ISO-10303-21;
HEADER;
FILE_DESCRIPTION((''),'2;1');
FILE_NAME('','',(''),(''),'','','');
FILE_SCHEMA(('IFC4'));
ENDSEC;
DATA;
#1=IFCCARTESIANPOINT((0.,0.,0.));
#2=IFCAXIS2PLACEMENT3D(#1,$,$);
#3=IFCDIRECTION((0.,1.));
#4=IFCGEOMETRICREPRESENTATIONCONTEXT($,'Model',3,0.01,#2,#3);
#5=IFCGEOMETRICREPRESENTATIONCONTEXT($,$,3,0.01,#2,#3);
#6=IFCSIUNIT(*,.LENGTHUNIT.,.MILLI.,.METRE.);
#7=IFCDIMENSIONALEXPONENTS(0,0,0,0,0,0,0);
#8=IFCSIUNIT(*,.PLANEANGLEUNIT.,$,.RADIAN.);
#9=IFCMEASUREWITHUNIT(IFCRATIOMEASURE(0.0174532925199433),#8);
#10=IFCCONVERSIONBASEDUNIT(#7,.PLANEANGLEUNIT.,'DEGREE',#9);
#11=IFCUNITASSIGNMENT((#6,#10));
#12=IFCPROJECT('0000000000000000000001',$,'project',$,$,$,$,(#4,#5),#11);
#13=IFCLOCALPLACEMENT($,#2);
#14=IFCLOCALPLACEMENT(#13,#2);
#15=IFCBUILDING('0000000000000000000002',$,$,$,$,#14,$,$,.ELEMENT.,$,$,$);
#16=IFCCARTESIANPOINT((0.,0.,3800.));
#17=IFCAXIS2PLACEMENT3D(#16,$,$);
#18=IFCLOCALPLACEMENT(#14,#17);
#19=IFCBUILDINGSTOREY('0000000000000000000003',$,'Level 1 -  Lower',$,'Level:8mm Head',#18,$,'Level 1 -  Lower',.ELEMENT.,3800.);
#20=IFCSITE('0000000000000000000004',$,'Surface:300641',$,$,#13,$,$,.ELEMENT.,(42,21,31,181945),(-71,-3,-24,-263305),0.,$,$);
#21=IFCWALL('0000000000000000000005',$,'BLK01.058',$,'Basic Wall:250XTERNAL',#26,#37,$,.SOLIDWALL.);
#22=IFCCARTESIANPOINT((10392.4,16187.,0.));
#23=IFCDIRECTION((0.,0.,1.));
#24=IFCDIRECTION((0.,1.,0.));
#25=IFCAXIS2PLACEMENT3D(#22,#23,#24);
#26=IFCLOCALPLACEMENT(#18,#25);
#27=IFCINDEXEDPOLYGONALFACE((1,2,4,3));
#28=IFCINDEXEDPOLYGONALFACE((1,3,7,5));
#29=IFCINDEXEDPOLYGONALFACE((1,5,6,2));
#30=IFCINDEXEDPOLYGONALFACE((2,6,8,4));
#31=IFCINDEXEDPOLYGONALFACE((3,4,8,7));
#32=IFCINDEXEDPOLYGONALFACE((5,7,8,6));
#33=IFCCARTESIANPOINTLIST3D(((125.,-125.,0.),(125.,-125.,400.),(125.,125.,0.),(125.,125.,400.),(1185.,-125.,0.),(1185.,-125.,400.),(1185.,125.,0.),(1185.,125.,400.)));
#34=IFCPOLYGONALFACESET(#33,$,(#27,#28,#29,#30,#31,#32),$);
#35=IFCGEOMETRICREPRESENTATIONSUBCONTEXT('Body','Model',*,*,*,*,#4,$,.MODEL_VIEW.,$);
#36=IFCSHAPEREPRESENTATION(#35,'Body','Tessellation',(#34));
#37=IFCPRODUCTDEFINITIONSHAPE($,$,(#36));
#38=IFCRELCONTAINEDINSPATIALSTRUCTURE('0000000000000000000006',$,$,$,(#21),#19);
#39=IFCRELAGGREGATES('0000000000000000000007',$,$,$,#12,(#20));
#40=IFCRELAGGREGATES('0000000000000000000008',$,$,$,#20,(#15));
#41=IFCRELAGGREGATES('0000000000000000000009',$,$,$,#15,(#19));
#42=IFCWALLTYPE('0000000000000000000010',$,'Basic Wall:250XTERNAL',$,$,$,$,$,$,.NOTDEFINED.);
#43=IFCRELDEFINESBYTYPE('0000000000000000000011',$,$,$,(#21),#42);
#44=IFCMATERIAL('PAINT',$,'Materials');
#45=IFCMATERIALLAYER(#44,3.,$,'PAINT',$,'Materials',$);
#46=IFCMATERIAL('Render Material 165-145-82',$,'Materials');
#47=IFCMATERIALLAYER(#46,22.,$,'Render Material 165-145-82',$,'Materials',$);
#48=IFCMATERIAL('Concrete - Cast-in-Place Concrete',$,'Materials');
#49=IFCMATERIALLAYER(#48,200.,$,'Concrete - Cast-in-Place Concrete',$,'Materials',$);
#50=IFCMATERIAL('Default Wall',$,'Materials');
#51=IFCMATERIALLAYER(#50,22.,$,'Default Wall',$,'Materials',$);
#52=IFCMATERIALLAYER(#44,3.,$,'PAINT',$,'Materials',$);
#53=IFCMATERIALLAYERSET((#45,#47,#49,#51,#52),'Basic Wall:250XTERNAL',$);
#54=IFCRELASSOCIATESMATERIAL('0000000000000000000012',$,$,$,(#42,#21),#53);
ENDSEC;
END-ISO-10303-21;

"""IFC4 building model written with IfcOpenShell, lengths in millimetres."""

from ifc_helpers import new_model, entity, si_unit, converted_unit, direction, frame, frame_2d, origin, place, context, subcontext, project, spatial, rectangle, extrude, clip, halfspace, material, layer, layer_set, layer_usage, type_object, element, save


model = new_model("IFC4")

# Units and contexts
model_context = context("Model", 3, precision=0.01, world=origin(), true_north=direction((0.0, 1.0)))
context_of_model = context(None, 3, precision=0.01, world=origin(), true_north=direction((0.0, 1.0)))
body_context = subcontext(model_context, "Body", "Model", "MODEL_VIEW")
ifc_project = project(units=[si_unit("LENGTHUNIT", "METRE", prefix="MILLI"), converted_unit("PLANEANGLEUNIT", "DEGREE", entity("IfcRatioMeasure", 0.0174532925199433), si_unit("PLANEANGLEUNIT", "RADIAN"), dimensions=[0, 0, 0, 0, 0, 0, 0])], contexts=[model_context, context_of_model])

# Site, building, storey
site_placement = place(None, origin())
site = spatial("IfcSite", under=ifc_project, at=site_placement, Name="Surface:300641", CompositionType="ELEMENT", RefLatitude=(42, 21, 31, 181945), RefLongitude=(-71, -3, -24, -263305), RefElevation=0.0)
building_placement = place(site_placement, origin())
building = spatial("IfcBuilding", under=site, at=building_placement, CompositionType="ELEMENT")
storey_placement = place(building_placement, frame((0.0, 0.0, 3800.0)))
storey = spatial("IfcBuildingStorey", under=building, at=storey_placement, Name="Level 1 -  Lower", ObjectType="Level:8mm Head", LongName="Level 1 -  Lower", CompositionType="ELEMENT", Elevation=3800.0)

# Shared definitions
ifc_material_1 = material(Name="Concrete - Cast-in-Place Concrete", Category="Materials")

# Wall
ifc_material_2 = material(Name="PAINT", Category="Materials")
ifc_layer_1 = layer(ifc_material_2, 3.0, Name="PAINT", Category="Materials")
ifc_material_3 = material(Name="Render Material 165-145-82", Category="Materials")
ifc_layer_2 = layer(ifc_material_3, 22.0, Name="Render Material 165-145-82", Category="Materials")
ifc_layer_3 = layer(ifc_material_1, 200.0, Name="Concrete - Cast-in-Place Concrete", Category="Materials")
ifc_material_4 = material(Name="Default Wall", Category="Materials")
ifc_layer_4 = layer(ifc_material_4, 22.0, Name="Default Wall", Category="Materials")
ifc_layer_5 = layer(ifc_material_2, 3.0, Name="PAINT", Category="Materials")
ifc_layer_set_1 = layer_set([ifc_layer_1, ifc_layer_2, ifc_layer_3, ifc_layer_4, ifc_layer_5], Name="Basic Wall:250XTERNAL")
wall_type_1 = type_object("IfcWallType", Name="Basic Wall:250XTERNAL", PredefinedType="NOTDEFINED", material=ifc_layer_set_1)
ifc_layer_usage_1 = layer_usage(ifc_layer_set_1, "AXIS2", "NEGATIVE", 125.0)
wall_1_placement = place(storey_placement, frame((10392.4, 16187.0, 0.0), z_axis=(0.0, 0.0, 1.0), x_axis=(0.0, 1.0, 0.0)))
element("IfcWall", 1, at=wall_1_placement, inside=storey, type_object=wall_type_1, material=ifc_layer_usage_1, Name="BLK01.058", ObjectType="Basic Wall:250XTERNAL", PredefinedType="SOLIDWALL", context=body_context, shape_type="Clipping", body=[
    clip(extrude(rectangle(XDim=1060.0, YDim=250.0, at=frame_2d((655.0, 0.0), x_axis=(-1.0, 0.0))), origin(), (0.0, 0.0, 1.0), 400.0), halfspace(origin(), True)),
])

save(model, "model.ifc")
